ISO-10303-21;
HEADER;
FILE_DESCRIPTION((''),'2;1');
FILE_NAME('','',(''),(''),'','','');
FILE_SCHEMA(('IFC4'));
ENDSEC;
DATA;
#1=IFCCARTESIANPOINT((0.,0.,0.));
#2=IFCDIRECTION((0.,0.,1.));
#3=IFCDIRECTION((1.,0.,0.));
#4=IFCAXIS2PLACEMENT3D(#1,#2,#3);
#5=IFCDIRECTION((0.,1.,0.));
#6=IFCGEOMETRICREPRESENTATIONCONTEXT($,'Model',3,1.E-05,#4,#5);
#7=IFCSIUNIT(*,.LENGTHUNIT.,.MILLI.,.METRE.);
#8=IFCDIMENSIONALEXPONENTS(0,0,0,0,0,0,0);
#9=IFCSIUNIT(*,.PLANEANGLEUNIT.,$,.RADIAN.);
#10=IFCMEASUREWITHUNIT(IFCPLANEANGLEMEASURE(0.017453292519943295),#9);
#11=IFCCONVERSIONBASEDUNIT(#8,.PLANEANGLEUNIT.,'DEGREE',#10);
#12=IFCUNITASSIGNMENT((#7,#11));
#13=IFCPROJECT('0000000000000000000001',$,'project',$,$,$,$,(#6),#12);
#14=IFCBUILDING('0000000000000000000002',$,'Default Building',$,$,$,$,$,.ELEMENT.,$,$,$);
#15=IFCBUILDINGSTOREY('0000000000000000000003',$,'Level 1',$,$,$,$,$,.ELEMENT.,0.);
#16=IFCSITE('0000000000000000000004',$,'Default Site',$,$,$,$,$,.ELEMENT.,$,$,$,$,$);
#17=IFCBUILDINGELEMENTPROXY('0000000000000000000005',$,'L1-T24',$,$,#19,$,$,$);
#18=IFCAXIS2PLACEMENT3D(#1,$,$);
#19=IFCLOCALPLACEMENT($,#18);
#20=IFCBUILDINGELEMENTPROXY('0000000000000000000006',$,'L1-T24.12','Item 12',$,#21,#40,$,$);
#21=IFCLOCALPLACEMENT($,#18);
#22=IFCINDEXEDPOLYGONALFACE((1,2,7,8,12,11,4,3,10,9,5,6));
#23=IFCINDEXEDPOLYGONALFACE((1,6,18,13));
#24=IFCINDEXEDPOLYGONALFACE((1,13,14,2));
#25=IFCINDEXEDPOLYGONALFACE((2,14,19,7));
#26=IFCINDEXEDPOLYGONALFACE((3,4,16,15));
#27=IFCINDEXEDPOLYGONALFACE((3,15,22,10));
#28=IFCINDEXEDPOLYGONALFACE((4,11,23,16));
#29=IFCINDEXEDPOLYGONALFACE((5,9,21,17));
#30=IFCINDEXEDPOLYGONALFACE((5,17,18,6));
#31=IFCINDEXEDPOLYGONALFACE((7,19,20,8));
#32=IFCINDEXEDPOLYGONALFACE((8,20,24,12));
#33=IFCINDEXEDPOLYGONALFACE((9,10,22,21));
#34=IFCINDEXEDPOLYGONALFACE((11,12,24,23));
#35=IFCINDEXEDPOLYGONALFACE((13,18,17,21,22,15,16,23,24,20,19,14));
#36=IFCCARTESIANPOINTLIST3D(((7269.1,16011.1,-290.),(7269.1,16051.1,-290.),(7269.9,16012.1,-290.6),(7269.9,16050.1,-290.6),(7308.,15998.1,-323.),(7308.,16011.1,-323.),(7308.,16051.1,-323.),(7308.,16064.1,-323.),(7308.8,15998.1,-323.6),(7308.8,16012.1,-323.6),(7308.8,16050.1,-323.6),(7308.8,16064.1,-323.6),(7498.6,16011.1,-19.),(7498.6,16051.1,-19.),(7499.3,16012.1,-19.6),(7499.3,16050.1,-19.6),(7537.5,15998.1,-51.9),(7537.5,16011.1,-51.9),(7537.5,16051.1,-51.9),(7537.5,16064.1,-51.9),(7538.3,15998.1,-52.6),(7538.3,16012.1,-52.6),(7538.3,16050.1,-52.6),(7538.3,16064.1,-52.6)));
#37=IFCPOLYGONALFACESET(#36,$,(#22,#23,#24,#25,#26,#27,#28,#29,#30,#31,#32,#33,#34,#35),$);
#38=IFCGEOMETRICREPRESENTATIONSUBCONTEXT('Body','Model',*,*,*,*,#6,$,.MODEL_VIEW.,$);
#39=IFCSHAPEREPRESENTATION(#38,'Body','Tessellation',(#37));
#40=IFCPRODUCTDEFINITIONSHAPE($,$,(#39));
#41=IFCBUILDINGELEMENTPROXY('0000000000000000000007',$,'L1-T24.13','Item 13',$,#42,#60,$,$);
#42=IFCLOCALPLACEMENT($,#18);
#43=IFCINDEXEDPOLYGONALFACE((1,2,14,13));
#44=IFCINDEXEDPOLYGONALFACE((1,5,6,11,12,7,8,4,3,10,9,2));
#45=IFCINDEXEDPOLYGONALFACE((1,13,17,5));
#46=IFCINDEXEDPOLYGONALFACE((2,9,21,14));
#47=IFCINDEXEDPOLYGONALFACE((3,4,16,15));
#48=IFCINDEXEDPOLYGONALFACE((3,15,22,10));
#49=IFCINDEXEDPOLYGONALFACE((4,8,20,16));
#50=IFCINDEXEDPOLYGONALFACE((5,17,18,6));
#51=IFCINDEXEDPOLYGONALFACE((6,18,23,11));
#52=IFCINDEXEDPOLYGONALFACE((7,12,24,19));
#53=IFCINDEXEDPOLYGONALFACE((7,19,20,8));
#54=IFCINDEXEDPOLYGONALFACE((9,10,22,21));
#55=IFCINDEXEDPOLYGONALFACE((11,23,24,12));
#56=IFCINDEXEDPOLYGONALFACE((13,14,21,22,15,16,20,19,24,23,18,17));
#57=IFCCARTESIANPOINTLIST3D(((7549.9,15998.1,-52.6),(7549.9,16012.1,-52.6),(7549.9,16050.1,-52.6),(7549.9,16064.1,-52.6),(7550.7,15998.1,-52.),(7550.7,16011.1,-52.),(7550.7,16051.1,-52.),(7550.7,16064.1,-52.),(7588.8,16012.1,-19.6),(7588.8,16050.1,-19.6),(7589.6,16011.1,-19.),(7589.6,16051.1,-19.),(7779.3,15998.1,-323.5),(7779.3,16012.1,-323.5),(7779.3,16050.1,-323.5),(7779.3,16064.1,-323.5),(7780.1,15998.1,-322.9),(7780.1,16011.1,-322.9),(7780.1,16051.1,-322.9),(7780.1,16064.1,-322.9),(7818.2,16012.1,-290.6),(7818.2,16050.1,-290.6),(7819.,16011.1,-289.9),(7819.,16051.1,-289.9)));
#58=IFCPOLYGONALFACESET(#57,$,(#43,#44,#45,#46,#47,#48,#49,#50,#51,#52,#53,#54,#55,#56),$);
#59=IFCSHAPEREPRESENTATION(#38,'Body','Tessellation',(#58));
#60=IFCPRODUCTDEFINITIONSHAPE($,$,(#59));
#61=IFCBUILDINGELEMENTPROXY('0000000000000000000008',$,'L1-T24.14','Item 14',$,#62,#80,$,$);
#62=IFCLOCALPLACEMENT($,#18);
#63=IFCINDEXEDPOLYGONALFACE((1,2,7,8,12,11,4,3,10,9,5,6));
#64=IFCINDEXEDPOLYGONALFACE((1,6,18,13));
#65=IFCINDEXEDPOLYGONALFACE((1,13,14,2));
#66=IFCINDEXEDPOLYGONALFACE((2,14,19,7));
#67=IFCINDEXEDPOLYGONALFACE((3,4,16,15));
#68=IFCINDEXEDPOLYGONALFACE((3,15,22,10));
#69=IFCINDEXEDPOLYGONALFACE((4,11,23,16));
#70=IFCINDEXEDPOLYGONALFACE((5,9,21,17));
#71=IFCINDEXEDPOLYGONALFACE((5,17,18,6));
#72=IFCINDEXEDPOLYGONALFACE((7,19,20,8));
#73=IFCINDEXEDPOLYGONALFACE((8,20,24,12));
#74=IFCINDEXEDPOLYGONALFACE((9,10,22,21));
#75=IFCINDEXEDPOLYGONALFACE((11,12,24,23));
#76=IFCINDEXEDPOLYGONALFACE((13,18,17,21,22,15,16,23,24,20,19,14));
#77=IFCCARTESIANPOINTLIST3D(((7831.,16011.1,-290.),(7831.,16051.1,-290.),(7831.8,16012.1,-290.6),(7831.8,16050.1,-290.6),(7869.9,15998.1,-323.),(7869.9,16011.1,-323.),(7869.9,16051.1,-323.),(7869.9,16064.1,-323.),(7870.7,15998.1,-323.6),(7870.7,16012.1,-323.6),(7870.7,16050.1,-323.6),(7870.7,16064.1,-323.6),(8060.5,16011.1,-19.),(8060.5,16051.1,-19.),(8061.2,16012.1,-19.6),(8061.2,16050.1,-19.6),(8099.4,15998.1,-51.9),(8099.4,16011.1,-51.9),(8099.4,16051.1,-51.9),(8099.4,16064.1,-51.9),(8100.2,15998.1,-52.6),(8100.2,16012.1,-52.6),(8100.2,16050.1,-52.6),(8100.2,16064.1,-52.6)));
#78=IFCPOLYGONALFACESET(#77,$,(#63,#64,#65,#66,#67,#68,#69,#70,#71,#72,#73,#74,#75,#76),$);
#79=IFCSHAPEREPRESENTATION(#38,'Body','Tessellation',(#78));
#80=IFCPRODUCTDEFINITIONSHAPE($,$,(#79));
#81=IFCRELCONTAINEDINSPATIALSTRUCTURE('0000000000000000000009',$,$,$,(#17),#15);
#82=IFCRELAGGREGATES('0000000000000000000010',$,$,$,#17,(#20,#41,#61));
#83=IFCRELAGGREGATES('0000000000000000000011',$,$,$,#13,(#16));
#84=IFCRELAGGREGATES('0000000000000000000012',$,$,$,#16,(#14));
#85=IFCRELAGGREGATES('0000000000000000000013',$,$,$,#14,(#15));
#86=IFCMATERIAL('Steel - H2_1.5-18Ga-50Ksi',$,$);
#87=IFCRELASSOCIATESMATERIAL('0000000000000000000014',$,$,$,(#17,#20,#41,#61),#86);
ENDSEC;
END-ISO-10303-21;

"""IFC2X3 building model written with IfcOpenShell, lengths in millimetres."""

from ifc_helpers import new_model, entity, si_unit, converted_unit, direction, frame, origin, origin_with_axes, place, context, subcontext, project, spatial, polyline, outline, extrude, material, element, aggregate, save


model = new_model("IFC2X3")

# Units and contexts
model_context = context("Model", 3, precision=1e-05, world=origin_with_axes(), true_north=direction((0.0, 1.0, 0.0)))
body_context = subcontext(model_context, "Body", "Model", "MODEL_VIEW")
ifc_project = project(units=[si_unit("LENGTHUNIT", "METRE", prefix="MILLI"), converted_unit("PLANEANGLEUNIT", "DEGREE", entity("IfcPlaneAngleMeasure", 0.017453292519943295), si_unit("PLANEANGLEUNIT", "RADIAN"), dimensions=[0, 0, 0, 0, 0, 0, 0])], contexts=[model_context])

# Site, building, storey
site = spatial("IfcSite", under=ifc_project, Name="Default Site", CompositionType="ELEMENT")
building = spatial("IfcBuilding", under=site, Name="Default Building", CompositionType="ELEMENT")
storey = spatial("IfcBuildingStorey", under=building, Name="Level 1", CompositionType="ELEMENT", Elevation=0.0)

# Building element proxies
ifc_material_1 = material(Name="Steel - H2_1.5-18Ga-50Ksi")
proxy_1 = element("IfcBuildingElementProxy", 1, inside=storey, material=ifc_material_1, Name="L1-T24")
proxy_2_placement = place(None, frame((7308.8, 15998.1, -323.6), z_axis=(0.646, 0.0, 0.763), x_axis=(0.0, 40.0, 0.0)))
proxy_2 = element("IfcBuildingElementProxy", 2, at=proxy_2_placement, material=ifc_material_1, Name="L1-T24.12", Description="Item 12", context=body_context, shape_type="SweptSolid", body=[
    extrude(outline(polyline([(0.0, 0.0), (14.0, 0.0), (14.0, 51.0), (52.0, 51.0), (52.0, 0.0), (66.0, 0.0), (66.0, 1.0), (53.0, 1.0), (53.0, 52.0), (13.0, 52.0), (13.0, 1.0), (0.0, 1.0), (0.0, 0.0)])), origin(), (0.0, 0.0, 1.0), 355.1),
])
proxy_3_placement = place(None, frame((7549.9, 15998.1, -52.6), z_axis=(0.646, 0.0, -0.763), x_axis=(0.0, 40.0, 0.0)))
proxy_3 = element("IfcBuildingElementProxy", 3, at=proxy_3_placement, material=ifc_material_1, Name="L1-T24.13", Description="Item 13", context=body_context, shape_type="SweptSolid", body=[
    extrude(outline(polyline([(0.0, 0.0), (14.0, 0.0), (14.0, 51.0), (52.0, 51.0), (52.0, 0.0), (66.0, 0.0), (66.0, 1.0), (53.0, 1.0), (53.0, 52.0), (13.0, 52.0), (13.0, 1.0), (0.0, 1.0), (0.0, 0.0)])), origin(), (0.0, 0.0, 1.0), 355.0),
])
proxy_4_placement = place(None, frame((7870.7, 15998.1, -323.6), z_axis=(0.646, 0.0, 0.763), x_axis=(0.0, 40.0, 0.0)))
proxy_4 = element("IfcBuildingElementProxy", 4, at=proxy_4_placement, material=ifc_material_1, Name="L1-T24.14", Description="Item 14", context=body_context, shape_type="SweptSolid", body=[
    extrude(outline(polyline([(0.0, 0.0), (14.0, 0.0), (14.0, 51.0), (52.0, 51.0), (52.0, 0.0), (66.0, 0.0), (66.0, 1.0), (53.0, 1.0), (53.0, 52.0), (13.0, 52.0), (13.0, 1.0), (0.0, 1.0), (0.0, 0.0)])), origin(), (0.0, 0.0, 1.0), 355.1),
])
aggregate(proxy_1, [proxy_2, proxy_3, proxy_4])

save(model, "model.ifc")
